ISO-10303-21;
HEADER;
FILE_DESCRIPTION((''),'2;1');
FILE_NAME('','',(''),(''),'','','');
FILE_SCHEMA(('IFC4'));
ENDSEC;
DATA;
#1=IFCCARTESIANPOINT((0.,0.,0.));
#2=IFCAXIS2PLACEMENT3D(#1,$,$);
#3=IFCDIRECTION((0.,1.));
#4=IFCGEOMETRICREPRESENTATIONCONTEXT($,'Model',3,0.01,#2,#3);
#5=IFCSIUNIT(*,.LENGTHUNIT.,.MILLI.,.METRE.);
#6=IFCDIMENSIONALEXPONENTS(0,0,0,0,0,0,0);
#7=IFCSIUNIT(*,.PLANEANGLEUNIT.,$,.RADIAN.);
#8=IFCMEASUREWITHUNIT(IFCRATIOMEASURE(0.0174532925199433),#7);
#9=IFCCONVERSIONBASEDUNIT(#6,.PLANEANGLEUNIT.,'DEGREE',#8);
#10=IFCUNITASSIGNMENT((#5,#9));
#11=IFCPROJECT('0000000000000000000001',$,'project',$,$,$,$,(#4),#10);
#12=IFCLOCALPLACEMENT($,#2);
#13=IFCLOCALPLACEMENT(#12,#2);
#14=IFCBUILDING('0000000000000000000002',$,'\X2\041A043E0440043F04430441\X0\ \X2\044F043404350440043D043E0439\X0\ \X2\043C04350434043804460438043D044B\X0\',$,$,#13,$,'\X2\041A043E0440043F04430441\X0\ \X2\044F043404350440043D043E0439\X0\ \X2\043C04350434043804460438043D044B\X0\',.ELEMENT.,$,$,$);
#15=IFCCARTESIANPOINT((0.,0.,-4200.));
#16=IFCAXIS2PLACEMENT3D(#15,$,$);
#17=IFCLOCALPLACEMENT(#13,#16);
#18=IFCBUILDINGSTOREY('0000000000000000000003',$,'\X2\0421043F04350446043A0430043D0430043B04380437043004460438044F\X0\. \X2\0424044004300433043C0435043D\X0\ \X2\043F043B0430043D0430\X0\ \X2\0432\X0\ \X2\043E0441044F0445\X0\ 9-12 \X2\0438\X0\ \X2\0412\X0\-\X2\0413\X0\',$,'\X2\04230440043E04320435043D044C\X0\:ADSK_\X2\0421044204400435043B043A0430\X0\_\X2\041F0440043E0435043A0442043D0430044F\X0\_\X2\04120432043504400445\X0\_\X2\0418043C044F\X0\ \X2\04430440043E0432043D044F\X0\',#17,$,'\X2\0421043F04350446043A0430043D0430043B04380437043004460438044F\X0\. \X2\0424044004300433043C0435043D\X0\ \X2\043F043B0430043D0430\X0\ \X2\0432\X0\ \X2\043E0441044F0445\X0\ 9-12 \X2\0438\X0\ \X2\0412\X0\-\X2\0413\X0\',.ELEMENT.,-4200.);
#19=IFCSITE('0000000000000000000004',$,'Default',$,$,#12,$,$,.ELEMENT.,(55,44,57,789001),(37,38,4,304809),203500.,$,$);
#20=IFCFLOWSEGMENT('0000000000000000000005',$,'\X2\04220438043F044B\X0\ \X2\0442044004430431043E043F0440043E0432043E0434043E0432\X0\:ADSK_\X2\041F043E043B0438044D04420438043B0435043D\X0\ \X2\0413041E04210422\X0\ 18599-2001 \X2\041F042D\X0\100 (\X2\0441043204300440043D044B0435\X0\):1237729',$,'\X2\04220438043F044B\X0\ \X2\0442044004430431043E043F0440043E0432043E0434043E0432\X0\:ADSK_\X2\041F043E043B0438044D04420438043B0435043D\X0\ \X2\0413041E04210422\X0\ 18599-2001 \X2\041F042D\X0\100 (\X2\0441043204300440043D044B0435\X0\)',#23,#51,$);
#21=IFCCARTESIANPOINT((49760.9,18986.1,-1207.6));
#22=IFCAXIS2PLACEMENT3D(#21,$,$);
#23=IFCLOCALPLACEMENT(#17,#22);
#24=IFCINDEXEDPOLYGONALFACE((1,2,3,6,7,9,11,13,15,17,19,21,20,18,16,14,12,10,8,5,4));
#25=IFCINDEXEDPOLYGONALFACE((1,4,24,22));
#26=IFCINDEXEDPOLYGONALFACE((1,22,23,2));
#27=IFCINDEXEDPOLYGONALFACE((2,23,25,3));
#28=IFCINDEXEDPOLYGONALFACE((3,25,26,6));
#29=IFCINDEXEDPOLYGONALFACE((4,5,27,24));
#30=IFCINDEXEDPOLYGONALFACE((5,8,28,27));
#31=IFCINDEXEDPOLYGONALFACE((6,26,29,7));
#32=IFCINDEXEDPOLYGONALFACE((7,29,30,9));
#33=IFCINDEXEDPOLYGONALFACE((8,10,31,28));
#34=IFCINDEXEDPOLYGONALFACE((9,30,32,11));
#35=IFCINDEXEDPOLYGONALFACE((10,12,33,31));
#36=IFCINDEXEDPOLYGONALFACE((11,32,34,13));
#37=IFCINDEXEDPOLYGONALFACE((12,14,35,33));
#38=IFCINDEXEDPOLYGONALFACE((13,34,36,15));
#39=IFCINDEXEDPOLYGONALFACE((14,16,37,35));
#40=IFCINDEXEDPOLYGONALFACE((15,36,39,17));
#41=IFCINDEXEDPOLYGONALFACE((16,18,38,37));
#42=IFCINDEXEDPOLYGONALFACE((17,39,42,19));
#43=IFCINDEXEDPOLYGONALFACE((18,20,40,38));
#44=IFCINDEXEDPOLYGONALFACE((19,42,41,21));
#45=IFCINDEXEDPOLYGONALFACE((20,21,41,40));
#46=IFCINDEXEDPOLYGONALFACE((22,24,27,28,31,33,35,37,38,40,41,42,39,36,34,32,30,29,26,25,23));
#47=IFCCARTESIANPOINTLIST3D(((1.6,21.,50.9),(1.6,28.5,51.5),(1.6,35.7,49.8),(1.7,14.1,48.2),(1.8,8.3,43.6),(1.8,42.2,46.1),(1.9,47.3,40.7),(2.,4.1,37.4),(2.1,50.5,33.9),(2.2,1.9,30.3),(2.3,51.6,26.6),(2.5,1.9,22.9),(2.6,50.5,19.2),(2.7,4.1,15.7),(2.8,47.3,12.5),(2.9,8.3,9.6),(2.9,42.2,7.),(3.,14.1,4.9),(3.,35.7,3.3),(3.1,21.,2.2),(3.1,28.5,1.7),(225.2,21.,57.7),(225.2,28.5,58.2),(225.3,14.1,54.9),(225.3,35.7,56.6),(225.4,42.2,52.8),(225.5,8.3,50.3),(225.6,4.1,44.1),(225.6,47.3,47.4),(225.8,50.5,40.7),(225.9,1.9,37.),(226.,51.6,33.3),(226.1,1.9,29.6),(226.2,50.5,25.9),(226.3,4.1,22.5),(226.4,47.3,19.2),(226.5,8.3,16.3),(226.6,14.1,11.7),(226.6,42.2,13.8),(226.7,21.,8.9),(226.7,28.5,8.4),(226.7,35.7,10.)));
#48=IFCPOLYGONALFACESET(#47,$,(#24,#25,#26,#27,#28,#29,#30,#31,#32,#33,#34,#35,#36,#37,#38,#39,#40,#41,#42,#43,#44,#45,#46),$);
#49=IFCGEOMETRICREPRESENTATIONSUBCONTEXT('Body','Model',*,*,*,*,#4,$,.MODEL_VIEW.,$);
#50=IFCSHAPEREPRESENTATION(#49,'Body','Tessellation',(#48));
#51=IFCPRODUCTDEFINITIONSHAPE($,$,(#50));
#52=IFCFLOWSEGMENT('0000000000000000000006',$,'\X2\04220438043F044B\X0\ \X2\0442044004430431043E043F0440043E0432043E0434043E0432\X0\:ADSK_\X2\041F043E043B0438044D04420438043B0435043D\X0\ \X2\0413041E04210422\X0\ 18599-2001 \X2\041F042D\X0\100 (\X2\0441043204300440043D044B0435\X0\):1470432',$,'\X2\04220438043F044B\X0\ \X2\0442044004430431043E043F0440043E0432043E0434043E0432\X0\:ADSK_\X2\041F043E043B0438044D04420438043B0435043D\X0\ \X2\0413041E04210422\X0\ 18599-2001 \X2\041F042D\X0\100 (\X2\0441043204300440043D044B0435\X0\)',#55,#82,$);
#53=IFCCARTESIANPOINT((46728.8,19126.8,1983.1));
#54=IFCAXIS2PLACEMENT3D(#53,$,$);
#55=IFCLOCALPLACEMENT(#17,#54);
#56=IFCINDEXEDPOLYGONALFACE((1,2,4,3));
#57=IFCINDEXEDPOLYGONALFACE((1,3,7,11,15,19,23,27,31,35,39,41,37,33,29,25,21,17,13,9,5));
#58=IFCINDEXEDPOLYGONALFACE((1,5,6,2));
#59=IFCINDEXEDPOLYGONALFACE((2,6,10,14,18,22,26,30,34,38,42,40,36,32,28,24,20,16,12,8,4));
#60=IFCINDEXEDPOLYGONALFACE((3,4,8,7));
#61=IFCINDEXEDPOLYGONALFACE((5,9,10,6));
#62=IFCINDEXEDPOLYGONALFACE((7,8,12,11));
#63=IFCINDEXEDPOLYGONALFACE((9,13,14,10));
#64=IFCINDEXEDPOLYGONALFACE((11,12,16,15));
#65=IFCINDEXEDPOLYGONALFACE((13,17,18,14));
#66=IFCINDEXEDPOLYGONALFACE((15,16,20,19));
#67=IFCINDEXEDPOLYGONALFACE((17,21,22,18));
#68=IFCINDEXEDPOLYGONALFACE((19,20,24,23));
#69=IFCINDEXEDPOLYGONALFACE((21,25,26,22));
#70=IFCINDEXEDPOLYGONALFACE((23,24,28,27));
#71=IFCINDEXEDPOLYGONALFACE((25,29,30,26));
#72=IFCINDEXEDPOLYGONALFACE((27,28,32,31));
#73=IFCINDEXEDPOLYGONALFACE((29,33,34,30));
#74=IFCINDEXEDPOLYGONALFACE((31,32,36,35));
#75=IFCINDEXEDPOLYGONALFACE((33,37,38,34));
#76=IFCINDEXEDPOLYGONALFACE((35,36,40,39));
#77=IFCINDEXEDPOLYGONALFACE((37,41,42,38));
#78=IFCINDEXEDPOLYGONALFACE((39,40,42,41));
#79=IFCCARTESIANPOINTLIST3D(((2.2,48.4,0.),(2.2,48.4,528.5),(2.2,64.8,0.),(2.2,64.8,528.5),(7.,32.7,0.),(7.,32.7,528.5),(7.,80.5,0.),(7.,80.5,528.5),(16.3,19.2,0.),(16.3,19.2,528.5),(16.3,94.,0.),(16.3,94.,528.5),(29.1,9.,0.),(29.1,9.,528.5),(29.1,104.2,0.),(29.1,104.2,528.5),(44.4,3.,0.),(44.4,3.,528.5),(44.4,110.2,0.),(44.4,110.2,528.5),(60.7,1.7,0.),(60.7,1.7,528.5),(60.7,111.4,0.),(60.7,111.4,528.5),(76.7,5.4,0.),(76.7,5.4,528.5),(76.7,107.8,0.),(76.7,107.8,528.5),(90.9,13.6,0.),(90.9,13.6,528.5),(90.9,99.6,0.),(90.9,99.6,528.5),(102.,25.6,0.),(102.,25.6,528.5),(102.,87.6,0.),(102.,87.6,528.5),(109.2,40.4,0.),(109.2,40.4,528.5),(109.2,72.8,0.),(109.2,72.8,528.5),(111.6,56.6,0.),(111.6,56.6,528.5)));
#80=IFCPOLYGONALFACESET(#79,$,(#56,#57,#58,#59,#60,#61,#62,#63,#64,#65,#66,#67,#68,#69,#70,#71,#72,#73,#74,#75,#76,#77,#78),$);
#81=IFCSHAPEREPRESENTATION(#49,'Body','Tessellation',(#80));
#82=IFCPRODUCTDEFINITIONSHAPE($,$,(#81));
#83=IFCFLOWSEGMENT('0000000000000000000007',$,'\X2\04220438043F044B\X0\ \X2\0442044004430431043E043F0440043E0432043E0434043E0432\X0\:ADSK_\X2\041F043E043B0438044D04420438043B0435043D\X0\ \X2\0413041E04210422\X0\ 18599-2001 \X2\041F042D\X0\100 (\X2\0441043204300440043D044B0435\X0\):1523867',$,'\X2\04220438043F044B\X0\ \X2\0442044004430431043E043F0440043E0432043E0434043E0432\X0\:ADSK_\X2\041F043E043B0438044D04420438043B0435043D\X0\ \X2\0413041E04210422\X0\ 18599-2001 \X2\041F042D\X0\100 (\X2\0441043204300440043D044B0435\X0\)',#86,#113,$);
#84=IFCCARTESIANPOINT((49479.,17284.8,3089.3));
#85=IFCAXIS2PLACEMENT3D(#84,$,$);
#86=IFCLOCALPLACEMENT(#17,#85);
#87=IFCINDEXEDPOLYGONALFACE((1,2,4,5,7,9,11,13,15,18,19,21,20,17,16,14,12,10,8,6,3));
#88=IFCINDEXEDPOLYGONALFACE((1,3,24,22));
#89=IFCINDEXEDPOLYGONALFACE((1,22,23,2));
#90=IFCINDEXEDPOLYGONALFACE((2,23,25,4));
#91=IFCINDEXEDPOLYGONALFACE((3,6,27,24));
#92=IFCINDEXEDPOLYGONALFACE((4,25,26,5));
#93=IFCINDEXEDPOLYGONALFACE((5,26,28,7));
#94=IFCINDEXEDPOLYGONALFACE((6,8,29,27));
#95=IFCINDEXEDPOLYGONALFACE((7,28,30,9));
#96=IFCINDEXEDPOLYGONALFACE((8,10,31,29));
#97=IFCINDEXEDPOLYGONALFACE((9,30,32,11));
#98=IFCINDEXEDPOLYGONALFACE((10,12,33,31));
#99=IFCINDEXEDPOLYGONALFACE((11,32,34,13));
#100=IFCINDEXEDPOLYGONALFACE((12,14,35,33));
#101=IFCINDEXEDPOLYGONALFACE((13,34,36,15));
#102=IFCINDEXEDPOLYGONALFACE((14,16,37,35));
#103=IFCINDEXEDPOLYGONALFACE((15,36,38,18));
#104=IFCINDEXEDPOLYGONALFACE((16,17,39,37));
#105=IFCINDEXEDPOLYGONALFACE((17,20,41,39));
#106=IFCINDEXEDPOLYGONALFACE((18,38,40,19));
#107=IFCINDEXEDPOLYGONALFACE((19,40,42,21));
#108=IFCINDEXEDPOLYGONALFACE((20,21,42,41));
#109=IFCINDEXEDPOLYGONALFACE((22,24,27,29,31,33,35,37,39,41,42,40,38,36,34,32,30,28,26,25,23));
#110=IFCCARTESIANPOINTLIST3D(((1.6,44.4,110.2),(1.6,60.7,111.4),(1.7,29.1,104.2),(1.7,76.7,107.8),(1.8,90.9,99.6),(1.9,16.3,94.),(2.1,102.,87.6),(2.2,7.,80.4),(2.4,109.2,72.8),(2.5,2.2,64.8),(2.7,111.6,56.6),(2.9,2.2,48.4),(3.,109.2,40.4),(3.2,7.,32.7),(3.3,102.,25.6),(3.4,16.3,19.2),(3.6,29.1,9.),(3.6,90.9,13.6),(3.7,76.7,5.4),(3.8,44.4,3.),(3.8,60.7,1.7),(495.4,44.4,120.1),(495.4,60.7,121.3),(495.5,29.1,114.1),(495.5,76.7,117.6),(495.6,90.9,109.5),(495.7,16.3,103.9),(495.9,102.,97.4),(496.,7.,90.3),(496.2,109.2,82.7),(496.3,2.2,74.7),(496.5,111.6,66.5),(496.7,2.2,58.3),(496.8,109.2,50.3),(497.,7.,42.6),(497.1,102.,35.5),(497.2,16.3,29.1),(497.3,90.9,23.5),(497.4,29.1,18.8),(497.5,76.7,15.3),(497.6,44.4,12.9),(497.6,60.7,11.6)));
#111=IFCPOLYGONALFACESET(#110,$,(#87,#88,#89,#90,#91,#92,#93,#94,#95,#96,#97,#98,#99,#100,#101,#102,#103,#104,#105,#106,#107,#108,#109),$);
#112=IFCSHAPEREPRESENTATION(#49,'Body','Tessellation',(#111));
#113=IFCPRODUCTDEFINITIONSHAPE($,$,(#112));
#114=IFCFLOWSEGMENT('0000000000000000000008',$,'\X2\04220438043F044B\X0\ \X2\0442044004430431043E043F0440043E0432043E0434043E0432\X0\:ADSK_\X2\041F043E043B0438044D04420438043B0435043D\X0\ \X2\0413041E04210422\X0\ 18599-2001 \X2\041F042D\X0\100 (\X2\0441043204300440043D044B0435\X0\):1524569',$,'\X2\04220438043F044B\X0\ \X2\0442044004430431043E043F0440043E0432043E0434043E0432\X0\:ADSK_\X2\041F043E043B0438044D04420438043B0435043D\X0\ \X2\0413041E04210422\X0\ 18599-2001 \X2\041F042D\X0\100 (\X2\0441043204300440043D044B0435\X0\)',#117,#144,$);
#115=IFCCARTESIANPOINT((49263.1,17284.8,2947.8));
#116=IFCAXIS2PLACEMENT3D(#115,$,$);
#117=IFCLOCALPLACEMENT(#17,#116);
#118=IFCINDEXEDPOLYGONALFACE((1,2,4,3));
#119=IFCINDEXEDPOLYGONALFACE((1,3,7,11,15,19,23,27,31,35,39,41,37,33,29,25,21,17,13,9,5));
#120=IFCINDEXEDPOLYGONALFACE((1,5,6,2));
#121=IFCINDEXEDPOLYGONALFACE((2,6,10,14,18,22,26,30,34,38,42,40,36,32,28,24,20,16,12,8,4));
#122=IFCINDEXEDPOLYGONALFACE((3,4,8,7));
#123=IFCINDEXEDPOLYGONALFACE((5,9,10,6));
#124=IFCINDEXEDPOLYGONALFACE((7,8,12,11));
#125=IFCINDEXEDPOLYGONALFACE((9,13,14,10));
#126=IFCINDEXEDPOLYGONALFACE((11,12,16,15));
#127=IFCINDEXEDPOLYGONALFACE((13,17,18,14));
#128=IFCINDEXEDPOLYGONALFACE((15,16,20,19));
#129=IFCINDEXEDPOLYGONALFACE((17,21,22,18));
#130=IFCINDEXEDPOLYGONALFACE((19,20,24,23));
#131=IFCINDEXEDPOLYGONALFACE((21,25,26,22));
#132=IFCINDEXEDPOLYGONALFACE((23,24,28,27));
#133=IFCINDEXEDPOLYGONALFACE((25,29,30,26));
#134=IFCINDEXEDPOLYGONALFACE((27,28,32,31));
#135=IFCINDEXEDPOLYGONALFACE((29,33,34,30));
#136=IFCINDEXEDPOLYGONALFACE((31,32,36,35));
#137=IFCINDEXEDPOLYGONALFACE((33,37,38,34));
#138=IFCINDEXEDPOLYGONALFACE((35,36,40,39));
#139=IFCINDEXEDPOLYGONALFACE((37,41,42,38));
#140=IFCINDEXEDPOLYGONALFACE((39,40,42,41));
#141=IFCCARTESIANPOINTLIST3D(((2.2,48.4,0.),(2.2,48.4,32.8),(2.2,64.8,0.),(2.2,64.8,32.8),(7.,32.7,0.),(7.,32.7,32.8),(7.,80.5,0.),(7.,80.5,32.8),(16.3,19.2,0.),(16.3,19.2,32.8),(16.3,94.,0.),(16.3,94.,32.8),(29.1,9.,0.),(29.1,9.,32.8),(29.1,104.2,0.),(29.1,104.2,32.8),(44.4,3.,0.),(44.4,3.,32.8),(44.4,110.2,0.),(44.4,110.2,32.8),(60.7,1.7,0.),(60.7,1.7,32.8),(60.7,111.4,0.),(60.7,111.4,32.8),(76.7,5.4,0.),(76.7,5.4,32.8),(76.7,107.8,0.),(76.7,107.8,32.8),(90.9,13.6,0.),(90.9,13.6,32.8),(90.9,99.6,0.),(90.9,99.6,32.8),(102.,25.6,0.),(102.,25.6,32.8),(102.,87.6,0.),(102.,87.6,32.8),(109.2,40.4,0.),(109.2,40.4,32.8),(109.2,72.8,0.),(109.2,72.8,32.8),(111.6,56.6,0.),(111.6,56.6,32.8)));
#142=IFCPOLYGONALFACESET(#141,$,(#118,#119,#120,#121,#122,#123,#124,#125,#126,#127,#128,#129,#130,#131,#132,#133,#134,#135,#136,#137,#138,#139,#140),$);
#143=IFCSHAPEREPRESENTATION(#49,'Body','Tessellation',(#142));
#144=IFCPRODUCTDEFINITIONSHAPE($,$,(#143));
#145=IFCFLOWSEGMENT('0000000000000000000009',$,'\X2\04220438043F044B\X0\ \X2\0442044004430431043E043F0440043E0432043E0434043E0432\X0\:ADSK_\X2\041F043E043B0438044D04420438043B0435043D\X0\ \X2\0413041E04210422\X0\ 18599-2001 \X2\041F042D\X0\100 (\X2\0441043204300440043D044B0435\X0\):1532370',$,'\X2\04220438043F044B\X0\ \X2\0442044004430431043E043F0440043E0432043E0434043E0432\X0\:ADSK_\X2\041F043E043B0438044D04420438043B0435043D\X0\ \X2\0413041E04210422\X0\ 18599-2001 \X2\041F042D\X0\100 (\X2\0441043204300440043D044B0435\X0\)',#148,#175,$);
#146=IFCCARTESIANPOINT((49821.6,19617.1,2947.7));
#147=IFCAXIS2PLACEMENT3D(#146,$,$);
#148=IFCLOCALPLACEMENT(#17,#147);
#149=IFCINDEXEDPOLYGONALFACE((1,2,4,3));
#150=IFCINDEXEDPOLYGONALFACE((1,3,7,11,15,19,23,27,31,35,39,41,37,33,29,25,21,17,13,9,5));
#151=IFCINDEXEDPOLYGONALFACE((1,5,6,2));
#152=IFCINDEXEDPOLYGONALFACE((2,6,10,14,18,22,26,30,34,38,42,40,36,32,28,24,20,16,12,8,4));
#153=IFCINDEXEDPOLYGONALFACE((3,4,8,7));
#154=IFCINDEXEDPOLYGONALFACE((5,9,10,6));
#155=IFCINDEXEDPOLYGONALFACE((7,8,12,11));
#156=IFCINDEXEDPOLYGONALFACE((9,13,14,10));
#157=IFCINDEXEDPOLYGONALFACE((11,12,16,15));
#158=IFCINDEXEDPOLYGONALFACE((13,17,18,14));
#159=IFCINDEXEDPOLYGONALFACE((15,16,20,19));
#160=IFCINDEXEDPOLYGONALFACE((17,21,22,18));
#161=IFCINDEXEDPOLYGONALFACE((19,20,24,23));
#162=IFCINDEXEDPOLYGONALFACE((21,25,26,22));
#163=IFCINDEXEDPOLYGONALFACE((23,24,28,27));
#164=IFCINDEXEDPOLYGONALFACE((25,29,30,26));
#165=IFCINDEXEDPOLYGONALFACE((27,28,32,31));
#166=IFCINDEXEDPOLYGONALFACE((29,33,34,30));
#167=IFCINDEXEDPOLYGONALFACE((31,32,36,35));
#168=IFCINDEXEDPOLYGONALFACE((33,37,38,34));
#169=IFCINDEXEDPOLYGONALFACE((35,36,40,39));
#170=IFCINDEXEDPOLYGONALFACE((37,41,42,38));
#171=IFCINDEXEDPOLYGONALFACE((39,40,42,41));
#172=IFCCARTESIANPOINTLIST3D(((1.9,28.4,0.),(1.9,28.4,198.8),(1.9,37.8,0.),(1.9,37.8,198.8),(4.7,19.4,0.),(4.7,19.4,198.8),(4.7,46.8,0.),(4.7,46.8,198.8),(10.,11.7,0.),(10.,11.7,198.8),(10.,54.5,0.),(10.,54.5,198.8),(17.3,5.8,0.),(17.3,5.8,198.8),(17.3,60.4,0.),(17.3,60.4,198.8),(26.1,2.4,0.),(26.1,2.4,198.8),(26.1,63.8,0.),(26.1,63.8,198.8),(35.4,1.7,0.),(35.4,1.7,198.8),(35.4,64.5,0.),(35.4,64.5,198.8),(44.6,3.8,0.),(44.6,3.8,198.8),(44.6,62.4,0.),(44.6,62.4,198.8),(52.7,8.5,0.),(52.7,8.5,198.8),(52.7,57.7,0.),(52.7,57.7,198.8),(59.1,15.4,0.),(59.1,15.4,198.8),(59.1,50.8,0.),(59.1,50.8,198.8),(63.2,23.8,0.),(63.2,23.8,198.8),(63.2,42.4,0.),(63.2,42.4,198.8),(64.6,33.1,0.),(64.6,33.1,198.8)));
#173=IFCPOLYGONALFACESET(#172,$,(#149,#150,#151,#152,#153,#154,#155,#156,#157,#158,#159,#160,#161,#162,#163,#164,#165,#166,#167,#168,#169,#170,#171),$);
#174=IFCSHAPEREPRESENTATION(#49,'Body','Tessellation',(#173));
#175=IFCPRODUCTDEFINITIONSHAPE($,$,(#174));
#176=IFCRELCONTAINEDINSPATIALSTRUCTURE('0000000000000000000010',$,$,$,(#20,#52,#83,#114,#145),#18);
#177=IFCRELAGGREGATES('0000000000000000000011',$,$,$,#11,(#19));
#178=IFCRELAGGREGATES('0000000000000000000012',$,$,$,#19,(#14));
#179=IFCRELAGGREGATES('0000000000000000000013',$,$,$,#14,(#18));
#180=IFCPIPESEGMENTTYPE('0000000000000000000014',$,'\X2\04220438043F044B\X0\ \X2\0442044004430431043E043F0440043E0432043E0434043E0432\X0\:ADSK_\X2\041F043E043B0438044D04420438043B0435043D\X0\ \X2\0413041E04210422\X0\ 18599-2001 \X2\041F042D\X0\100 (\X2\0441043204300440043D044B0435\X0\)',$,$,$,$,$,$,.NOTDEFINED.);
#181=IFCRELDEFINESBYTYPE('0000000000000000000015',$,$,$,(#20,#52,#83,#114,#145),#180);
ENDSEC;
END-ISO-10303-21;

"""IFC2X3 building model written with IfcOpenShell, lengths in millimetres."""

from ifc_helpers import new_model, entity, si_unit, converted_unit, direction, frame, origin, origin_2d_with_axis, place, context, subcontext, project, spatial, circle, extrude, type_object, element, save


model = new_model("IFC2X3")

# Units and contexts
model_context = context("Model", 3, precision=0.01, world=origin(), true_north=direction((0.0, 1.0)))
body_context = subcontext(model_context, "Body", "Model", "MODEL_VIEW")
ifc_project = project(units=[si_unit("LENGTHUNIT", "METRE", prefix="MILLI"), converted_unit("PLANEANGLEUNIT", "DEGREE", entity("IfcRatioMeasure", 0.0174532925199433), si_unit("PLANEANGLEUNIT", "RADIAN"), dimensions=[0, 0, 0, 0, 0, 0, 0])], contexts=[model_context])

# Site, building, storey
site_placement = place(None, frame((0.0, 0.0, 0.0)))
site = spatial("IfcSite", under=ifc_project, at=site_placement, Name="Default", CompositionType="ELEMENT", RefLatitude=(55, 44, 57, 789001), RefLongitude=(37, 38, 4, 304809), RefElevation=203500.0)
building_placement = place(site_placement, origin())
building = spatial("IfcBuilding", under=site, at=building_placement, Name="Корпус ядерной медицины", LongName="Корпус ядерной медицины", CompositionType="ELEMENT")
storey_placement = place(building_placement, frame((0.0, 0.0, -4200.0)))
storey = spatial("IfcBuildingStorey", under=building, at=storey_placement, Name="Спецканализация. Фрагмен плана в осях 9-12 и В-Г", ObjectType="Уровень:ADSK_Стрелка_Проектная_Вверх_Имя уровня", LongName="Спецканализация. Фрагмен плана в осях 9-12 и В-Г", CompositionType="ELEMENT", Elevation=-4200.0)

# Flow segments
pipe_segment_type = type_object("IfcPipeSegmentType", Name="Типы трубопроводов:ADSK_Полиэтилен ГОСТ 18599-2001 ПЭ100 (сварные)", PredefinedType="NOTDEFINED")
flow_segment_1_placement = place(storey_placement, frame((49760.9, 18986.1, -1207.6)))
element("IfcFlowSegment", 1, at=flow_segment_1_placement, inside=storey, type_object=pipe_segment_type, Name="Типы трубопроводов:ADSK_Полиэтилен ГОСТ 18599-2001 ПЭ100 (сварные):1237729", ObjectType="Типы трубопроводов:ADSK_Полиэтилен ГОСТ 18599-2001 ПЭ100 (сварные)", context=body_context, shape_type="SweptSolid", body=[
    extrude(circle(Radius=25.0, at=origin_2d_with_axis()), frame((2.3, 26.6, 26.6), z_axis=(0.99955, 0.0, 0.029987), x_axis=(0.0, 1.0, 0.0)), (0.0, 0.0, 1.0), 223.7),
])
flow_segment_2_placement = place(storey_placement, frame((46728.8, 19126.8, 1983.1)))
element("IfcFlowSegment", 2, at=flow_segment_2_placement, inside=storey, type_object=pipe_segment_type, Name="Типы трубопроводов:ADSK_Полиэтилен ГОСТ 18599-2001 ПЭ100 (сварные):1470432", ObjectType="Типы трубопроводов:ADSK_Полиэтилен ГОСТ 18599-2001 ПЭ100 (сварные)", context=body_context, shape_type="SweptSolid", body=[
    extrude(circle(Radius=55.0, at=origin_2d_with_axis()), frame((56.6, 56.6, 0.0)), (0.0, 0.0, 1.0), 528.5),
])
flow_segment_3_placement = place(storey_placement, frame((49479.0, 17284.8, 3089.3)))
element("IfcFlowSegment", 3, at=flow_segment_3_placement, inside=storey, type_object=pipe_segment_type, Name="Типы трубопроводов:ADSK_Полиэтилен ГОСТ 18599-2001 ПЭ100 (сварные):1523867", ObjectType="Типы трубопроводов:ADSK_Полиэтилен ГОСТ 18599-2001 ПЭ100 (сварные)", context=body_context, shape_type="SweptSolid", body=[
    extrude(circle(Radius=55.0, at=origin_2d_with_axis()), frame((2.7, 56.6, 56.6), z_axis=(0.9998, 0.0, 0.019997), x_axis=(0.0, 1.0, 0.0)), (0.0, 0.0, 1.0), 493.9),
])
flow_segment_4_placement = place(storey_placement, frame((49263.1, 17284.8, 2947.8)))
element("IfcFlowSegment", 4, at=flow_segment_4_placement, inside=storey, type_object=pipe_segment_type, Name="Типы трубопроводов:ADSK_Полиэтилен ГОСТ 18599-2001 ПЭ100 (сварные):1524569", ObjectType="Типы трубопроводов:ADSK_Полиэтилен ГОСТ 18599-2001 ПЭ100 (сварные)", context=body_context, shape_type="SweptSolid", body=[
    extrude(circle(Radius=55.0, at=origin_2d_with_axis()), frame((56.6, 56.6, 0.0)), (0.0, 0.0, 1.0), 32.8),
])
flow_segment_5_placement = place(storey_placement, frame((49821.6, 19617.1, 2947.7)))
element("IfcFlowSegment", 5, at=flow_segment_5_placement, inside=storey, type_object=pipe_segment_type, Name="Типы трубопроводов:ADSK_Полиэтилен ГОСТ 18599-2001 ПЭ100 (сварные):1532370", ObjectType="Типы трубопроводов:ADSK_Полиэтилен ГОСТ 18599-2001 ПЭ100 (сварные)", context=body_context, shape_type="SweptSolid", body=[
    extrude(circle(Radius=31.5, at=origin_2d_with_axis()), frame((33.1, 33.1, 0.0)), (0.0, 0.0, 1.0), 198.8),
])

save(model, "model.ifc")
